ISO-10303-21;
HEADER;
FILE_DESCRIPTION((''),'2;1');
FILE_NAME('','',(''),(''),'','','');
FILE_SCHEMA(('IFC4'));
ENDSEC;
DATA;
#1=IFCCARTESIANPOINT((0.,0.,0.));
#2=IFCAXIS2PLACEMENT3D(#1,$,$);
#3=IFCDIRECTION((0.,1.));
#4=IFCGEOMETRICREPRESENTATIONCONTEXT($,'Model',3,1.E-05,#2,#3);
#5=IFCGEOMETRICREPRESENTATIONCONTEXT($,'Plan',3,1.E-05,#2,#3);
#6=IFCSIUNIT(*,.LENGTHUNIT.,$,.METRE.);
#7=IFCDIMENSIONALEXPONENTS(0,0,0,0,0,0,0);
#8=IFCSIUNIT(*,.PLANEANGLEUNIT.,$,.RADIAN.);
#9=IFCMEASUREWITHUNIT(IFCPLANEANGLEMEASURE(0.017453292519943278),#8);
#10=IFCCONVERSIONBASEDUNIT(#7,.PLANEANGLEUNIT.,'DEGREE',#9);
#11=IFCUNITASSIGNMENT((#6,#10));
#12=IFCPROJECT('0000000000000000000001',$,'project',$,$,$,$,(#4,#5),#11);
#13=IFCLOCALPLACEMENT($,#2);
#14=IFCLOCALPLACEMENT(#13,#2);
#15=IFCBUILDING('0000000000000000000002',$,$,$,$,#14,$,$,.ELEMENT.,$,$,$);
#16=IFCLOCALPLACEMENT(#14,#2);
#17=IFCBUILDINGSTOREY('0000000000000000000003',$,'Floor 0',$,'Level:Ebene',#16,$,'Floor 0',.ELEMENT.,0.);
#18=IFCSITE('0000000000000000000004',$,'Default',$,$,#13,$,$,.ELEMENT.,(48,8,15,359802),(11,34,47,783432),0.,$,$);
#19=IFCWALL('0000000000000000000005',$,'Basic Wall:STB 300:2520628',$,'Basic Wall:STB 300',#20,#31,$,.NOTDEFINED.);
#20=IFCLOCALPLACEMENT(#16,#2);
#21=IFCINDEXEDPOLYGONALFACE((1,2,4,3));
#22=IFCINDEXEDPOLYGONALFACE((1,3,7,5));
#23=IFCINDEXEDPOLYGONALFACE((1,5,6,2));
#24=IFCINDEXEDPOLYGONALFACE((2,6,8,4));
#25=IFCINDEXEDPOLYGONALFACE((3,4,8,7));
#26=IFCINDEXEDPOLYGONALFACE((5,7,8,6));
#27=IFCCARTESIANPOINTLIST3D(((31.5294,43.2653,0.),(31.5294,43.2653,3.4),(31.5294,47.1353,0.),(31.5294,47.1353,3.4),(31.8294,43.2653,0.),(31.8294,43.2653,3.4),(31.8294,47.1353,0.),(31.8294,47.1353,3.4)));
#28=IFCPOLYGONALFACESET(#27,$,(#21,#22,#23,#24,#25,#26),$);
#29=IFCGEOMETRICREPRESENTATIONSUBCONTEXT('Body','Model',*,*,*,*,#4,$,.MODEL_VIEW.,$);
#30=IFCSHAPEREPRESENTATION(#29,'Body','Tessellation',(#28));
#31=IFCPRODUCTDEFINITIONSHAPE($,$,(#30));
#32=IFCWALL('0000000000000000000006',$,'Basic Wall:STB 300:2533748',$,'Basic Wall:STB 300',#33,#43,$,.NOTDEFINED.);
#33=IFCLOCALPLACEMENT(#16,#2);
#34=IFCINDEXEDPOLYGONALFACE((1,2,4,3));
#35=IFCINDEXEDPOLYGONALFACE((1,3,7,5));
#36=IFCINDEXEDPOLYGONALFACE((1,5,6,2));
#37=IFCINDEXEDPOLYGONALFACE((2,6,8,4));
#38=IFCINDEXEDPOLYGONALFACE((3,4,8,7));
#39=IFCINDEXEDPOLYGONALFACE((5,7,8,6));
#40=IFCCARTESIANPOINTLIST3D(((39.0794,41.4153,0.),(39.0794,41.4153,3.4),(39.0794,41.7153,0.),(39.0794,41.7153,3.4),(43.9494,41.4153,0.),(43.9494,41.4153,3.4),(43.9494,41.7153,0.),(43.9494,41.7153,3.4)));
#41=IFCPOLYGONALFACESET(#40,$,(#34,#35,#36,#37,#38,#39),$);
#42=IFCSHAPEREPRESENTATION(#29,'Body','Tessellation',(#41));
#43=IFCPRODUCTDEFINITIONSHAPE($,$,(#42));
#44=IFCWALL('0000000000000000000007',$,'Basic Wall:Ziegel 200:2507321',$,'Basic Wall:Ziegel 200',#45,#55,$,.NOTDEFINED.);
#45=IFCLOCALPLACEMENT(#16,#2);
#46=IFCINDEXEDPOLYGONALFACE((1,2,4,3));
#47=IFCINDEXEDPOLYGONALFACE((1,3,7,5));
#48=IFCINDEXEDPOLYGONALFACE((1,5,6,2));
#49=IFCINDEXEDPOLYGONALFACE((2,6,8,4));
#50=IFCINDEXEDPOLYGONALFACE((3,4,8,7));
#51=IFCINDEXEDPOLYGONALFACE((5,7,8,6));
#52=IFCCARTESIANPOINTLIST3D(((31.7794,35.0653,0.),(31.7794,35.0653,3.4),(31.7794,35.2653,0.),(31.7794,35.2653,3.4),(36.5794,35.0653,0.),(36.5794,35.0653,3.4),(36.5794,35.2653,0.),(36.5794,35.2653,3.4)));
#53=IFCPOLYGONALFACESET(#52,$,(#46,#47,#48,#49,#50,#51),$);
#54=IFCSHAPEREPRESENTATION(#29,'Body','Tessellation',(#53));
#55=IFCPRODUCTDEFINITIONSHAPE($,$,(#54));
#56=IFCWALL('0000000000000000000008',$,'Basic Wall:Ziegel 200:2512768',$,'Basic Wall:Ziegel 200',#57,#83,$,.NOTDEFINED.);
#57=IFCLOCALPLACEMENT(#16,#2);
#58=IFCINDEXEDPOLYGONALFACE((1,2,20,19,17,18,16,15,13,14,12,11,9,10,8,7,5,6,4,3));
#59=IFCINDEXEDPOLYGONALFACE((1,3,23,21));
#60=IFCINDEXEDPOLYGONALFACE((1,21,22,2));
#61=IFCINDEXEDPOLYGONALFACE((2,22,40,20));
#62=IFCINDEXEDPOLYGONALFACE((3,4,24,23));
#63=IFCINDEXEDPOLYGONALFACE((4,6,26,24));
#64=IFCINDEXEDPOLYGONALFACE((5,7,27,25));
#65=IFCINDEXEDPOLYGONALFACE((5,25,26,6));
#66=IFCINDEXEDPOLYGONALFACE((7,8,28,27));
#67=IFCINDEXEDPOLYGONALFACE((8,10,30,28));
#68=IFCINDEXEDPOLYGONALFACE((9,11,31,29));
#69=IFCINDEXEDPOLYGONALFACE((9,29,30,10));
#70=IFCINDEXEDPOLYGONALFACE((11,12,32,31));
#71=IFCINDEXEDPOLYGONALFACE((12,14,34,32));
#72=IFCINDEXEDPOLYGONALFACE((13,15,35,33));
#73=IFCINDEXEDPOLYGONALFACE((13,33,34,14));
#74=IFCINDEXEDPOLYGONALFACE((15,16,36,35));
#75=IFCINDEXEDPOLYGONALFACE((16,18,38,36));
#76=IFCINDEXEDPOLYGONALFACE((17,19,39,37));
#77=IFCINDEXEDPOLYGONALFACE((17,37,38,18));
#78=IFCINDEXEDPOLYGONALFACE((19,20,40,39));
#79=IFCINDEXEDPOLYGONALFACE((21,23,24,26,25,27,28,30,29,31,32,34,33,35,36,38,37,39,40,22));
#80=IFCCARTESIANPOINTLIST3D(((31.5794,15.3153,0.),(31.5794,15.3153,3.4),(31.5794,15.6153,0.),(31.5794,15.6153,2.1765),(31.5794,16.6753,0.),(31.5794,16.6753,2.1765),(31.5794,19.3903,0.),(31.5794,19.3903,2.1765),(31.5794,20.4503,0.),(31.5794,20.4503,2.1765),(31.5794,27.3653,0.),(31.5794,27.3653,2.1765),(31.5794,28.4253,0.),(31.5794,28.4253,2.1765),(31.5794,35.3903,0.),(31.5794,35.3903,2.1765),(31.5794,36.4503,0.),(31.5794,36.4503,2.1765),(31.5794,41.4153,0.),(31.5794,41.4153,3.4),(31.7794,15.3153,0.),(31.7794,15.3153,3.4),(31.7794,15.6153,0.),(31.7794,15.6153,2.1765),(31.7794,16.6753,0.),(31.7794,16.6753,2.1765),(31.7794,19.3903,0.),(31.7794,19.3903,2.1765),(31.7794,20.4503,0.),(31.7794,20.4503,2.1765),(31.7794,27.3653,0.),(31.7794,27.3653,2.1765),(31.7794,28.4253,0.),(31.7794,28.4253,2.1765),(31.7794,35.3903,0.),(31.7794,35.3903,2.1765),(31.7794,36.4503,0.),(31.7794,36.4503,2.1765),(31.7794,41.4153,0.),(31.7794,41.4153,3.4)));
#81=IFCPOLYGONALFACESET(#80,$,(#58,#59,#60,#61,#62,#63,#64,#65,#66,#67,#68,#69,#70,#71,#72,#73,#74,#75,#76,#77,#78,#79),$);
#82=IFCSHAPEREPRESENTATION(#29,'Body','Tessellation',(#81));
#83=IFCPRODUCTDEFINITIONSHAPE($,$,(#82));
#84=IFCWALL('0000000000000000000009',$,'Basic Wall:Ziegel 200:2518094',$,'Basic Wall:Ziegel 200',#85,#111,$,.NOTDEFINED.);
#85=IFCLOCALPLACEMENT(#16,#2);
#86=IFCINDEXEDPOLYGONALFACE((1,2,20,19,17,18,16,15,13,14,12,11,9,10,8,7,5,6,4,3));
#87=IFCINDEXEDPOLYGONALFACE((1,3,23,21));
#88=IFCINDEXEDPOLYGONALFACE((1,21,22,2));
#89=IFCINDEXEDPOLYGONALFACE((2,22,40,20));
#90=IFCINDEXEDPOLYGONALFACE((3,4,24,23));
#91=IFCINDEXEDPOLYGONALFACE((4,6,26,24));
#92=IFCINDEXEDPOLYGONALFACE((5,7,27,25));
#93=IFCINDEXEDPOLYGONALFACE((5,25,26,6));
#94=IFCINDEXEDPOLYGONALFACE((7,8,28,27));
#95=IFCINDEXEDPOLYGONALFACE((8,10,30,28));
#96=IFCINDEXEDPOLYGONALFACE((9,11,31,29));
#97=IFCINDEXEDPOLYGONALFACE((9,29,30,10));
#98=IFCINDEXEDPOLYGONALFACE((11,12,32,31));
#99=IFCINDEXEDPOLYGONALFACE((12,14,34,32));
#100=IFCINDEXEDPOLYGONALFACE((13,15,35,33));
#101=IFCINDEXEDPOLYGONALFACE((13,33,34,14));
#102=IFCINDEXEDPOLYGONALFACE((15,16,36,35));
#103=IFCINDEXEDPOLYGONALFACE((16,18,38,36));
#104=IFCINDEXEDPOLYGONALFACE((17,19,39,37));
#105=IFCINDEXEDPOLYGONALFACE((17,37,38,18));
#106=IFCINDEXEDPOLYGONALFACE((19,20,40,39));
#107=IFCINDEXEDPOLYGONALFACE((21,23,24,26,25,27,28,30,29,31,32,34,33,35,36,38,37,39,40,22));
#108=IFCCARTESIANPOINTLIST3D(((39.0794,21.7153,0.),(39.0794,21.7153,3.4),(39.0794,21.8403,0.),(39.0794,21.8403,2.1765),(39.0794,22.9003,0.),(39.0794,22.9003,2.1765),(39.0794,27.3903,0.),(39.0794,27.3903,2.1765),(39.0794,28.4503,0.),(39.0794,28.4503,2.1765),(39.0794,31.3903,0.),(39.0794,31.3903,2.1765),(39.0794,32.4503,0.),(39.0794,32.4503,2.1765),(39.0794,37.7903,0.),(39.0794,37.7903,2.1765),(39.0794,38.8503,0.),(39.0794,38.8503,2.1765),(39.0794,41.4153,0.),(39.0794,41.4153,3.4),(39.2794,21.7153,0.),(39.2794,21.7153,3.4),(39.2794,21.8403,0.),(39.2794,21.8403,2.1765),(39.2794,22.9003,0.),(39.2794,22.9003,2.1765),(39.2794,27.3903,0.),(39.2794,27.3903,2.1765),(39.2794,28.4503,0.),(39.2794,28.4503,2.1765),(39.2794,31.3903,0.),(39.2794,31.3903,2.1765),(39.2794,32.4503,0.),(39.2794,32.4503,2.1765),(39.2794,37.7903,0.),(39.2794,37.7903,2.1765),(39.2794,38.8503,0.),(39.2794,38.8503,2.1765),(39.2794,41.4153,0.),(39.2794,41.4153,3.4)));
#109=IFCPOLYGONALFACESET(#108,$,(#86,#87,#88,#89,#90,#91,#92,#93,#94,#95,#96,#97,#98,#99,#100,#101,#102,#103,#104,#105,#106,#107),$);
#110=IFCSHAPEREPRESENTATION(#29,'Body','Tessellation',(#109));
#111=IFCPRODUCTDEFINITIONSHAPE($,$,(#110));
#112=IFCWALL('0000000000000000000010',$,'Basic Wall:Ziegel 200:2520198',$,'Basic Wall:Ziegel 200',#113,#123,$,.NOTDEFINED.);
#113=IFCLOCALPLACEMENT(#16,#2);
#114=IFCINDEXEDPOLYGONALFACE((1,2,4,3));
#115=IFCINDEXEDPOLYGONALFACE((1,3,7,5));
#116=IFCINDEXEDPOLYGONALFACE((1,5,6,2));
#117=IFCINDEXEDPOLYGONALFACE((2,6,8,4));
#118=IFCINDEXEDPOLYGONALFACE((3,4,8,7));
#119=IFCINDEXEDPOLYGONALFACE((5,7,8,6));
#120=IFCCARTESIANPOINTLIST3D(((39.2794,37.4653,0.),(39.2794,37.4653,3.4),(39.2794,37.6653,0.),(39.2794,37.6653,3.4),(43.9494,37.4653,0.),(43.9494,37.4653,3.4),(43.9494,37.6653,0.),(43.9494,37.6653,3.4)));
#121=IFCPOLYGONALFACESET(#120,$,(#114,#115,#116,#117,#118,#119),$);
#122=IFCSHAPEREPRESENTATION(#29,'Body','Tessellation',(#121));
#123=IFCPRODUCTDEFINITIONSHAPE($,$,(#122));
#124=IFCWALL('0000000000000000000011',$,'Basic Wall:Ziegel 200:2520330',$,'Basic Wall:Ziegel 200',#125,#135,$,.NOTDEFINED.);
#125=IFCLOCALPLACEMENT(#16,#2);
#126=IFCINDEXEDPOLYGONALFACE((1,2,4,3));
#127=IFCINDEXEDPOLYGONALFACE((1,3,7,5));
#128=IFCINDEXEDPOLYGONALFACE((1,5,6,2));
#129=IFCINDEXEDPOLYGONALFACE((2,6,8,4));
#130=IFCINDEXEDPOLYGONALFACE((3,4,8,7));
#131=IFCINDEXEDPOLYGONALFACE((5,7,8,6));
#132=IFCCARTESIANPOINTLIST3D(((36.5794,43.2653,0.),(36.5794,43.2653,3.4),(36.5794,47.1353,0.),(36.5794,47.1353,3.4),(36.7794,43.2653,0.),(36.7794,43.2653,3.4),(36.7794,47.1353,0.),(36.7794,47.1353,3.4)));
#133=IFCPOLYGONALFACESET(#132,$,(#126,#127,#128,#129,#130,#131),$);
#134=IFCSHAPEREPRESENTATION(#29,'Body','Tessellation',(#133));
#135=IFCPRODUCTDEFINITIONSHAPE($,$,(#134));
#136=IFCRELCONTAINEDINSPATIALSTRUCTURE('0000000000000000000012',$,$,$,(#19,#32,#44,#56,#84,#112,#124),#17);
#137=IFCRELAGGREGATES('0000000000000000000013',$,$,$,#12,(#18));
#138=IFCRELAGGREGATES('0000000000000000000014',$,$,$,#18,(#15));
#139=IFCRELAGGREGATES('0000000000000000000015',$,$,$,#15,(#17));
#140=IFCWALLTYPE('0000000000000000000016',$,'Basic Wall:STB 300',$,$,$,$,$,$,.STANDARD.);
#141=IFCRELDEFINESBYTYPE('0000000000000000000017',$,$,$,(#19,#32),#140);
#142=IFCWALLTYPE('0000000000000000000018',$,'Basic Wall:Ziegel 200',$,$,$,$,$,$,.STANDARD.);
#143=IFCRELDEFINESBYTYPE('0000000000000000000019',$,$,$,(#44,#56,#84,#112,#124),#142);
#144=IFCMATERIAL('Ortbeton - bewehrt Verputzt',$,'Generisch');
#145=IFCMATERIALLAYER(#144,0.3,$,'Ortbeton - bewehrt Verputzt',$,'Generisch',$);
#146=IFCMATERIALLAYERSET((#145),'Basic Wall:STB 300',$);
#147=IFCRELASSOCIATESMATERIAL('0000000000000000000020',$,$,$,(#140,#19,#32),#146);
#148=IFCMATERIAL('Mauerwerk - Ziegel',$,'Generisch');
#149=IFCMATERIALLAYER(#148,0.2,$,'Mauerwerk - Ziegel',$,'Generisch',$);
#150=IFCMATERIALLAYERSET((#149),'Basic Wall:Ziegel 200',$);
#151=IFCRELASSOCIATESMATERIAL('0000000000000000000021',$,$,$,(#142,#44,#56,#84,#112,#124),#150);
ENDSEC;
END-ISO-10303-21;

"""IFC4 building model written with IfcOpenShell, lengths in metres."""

from ifc_helpers import new_model, entity, si_unit, converted_unit, direction, frame, frame_2d, origin, place, context, subcontext, project, spatial, polyline, rectangle, extrude, clip, bounded_halfspace, material, layer, layer_set, layer_usage, type_object, element, save


model = new_model("IFC4")

# Units and contexts
model_context = context("Model", 3, precision=1e-05, world=origin(), true_north=direction((0.0, 1.0)))
plan_context = context("Plan", 3, precision=1e-05, world=origin(), true_north=direction((0.0, 1.0)))
body_context = subcontext(model_context, "Body", "Model", "MODEL_VIEW")
ifc_project = project(units=[si_unit("LENGTHUNIT", "METRE"), converted_unit("PLANEANGLEUNIT", "DEGREE", entity("IfcPlaneAngleMeasure", 0.017453292519943278), si_unit("PLANEANGLEUNIT", "RADIAN"), dimensions=[0, 0, 0, 0, 0, 0, 0])], contexts=[model_context, plan_context])

# Site, building, storey
site_placement = place(None, origin())
site = spatial("IfcSite", under=ifc_project, at=site_placement, Name="Default", CompositionType="ELEMENT", RefLatitude=(48, 8, 15, 359802), RefLongitude=(11, 34, 47, 783432), RefElevation=0.0)
building_placement = place(site_placement, origin())
building = spatial("IfcBuilding", under=site, at=building_placement, CompositionType="ELEMENT")
storey_placement = place(building_placement, origin())
storey = spatial("IfcBuildingStorey", under=building, at=storey_placement, Name="Floor 0", ObjectType="Level:Ebene", LongName="Floor 0", CompositionType="ELEMENT", Elevation=0.0)

# Walls
ifc_material_1 = material(Name="Ortbeton - bewehrt Verputzt", Category="Generisch")
ifc_layer_1 = layer(ifc_material_1, 0.3, Name="Ortbeton - bewehrt Verputzt", Category="Generisch")
ifc_layer_set_1 = layer_set([ifc_layer_1], Name="Basic Wall:STB 300")
ifc_layer_usage_1 = layer_usage(ifc_layer_set_1, "AXIS2", "NEGATIVE", 0.15)
wall_type_1 = type_object("IfcWallType", Name="Basic Wall:STB 300", PredefinedType="STANDARD", material=ifc_layer_set_1)
wall_1_placement = place(storey_placement, frame((31.6794, 47.1353, 0.0), z_axis=(0.0, 0.0, 1.0), x_axis=(0.0, -1.0, 0.0)))
element("IfcWall", 1, at=wall_1_placement, inside=storey, type_object=wall_type_1, material=ifc_layer_usage_1, Name="Basic Wall:STB 300:2520628", ObjectType="Basic Wall:STB 300", PredefinedType="NOTDEFINED", context=body_context, shape_type="Clipping", body=[
    clip(extrude(rectangle(XDim=3.87, YDim=0.3, at=frame_2d((1.935, 0.0), x_axis=(-1.0, 0.0))), origin(), (0.0, 0.0, 1.0), 3.4), bounded_halfspace(frame((0.0, -0.15, 3.4), z_axis=(0.0, 0.0, -1.0), x_axis=(0.0, -1.0, 0.0)), True, frame((0.0, -0.15, 3.4)), polyline([(0.0, 0.0), (3.57, 0.0), (3.87, 0.0), (3.87, 0.3), (0.0, 0.3), (0.0, 0.0)]))),
])
wall_2_placement = place(storey_placement, frame((39.0794, 41.5653, 0.0)))
element("IfcWall", 2, at=wall_2_placement, inside=storey, type_object=wall_type_1, material=ifc_layer_usage_1, Name="Basic Wall:STB 300:2533748", ObjectType="Basic Wall:STB 300", PredefinedType="NOTDEFINED", context=body_context, shape_type="Clipping", body=[
    clip(extrude(rectangle(XDim=4.87, YDim=0.3, at=frame_2d((2.435, 0.0), x_axis=(-1.0, 0.0))), origin(), (0.0, 0.0, 1.0), 3.4), bounded_halfspace(frame((0.0, -0.15, 3.4), z_axis=(0.0, 0.0, -1.0), x_axis=(-1.0, 0.0, 0.0)), True, frame((0.0, -0.15, 3.4)), polyline([(0.0, 0.0), (0.2, 0.0), (4.87, 0.0), (4.87, 0.3), (0.0, 0.3), (0.0, 0.0)]))),
])
ifc_material_2 = material(Name="Mauerwerk - Ziegel", Category="Generisch")
ifc_layer_2 = layer(ifc_material_2, 0.2, Name="Mauerwerk - Ziegel", Category="Generisch")
ifc_layer_set_2 = layer_set([ifc_layer_2], Name="Basic Wall:Ziegel 200")
ifc_layer_usage_2 = layer_usage(ifc_layer_set_2, "AXIS2", "NEGATIVE", 0.1)
wall_type_2 = type_object("IfcWallType", Name="Basic Wall:Ziegel 200", PredefinedType="STANDARD", material=ifc_layer_set_2)
wall_3_placement = place(storey_placement, frame((36.5794, 35.1653, 0.0), z_axis=(0.0, 0.0, 1.0), x_axis=(-1.0, 0.0, 0.0)))
element("IfcWall", 3, at=wall_3_placement, inside=storey, type_object=wall_type_2, material=ifc_layer_usage_2, Name="Basic Wall:Ziegel 200:2507321", ObjectType="Basic Wall:Ziegel 200", PredefinedType="NOTDEFINED", context=body_context, shape_type="Clipping", body=[
    clip(extrude(rectangle(XDim=4.8, YDim=0.2, at=frame_2d((2.4, 0.0), x_axis=(-1.0, 0.0))), origin(), (0.0, 0.0, 1.0), 3.4), bounded_halfspace(frame((0.0, -0.1, 3.4), z_axis=(0.0, 0.0, -1.0), x_axis=(1.0, 0.0, 0.0)), True, frame((0.0, -0.1, 3.4)), polyline([(0.0, 0.0), (4.8, 0.0), (4.8, 0.2), (0.0, 0.2), (0.0, 0.0)]))),
])

# Walls, openings
wall_4_placement = place(storey_placement, frame((31.6794, 41.4153, 0.0), z_axis=(0.0, 0.0, 1.0), x_axis=(0.0, -1.0, 0.0)))
wall_4 = element("IfcWall", 4, at=wall_4_placement, inside=storey, type_object=wall_type_2, material=ifc_layer_usage_2, Name="Basic Wall:Ziegel 200:2512768", ObjectType="Basic Wall:Ziegel 200", PredefinedType="NOTDEFINED", context=body_context, shape_type="Clipping", body=[
    clip(extrude(rectangle(XDim=26.1, YDim=0.2, at=frame_2d((13.05, 0.0), x_axis=(-1.0, 0.0))), origin(), (0.0, 0.0, 1.0), 3.4), bounded_halfspace(frame((0.0, -0.1, 3.4), z_axis=(0.0, 0.0, -1.0), x_axis=(0.0, -1.0, 0.0)), True, frame((0.0, -0.1, 3.4)), polyline([(0.0, 0.0), (26.1, 0.0), (26.1, 0.2), (22.35, 0.2), (22.15, 0.2), (14.35, 0.2), (14.15, 0.2), (6.35, 0.2), (6.15, 0.2), (0.0, 0.2), (0.0, 0.0)]))),
])
opening_1_placement = place(wall_4_placement, frame((6.025, 0.1, 0.0)))
element("IfcOpeningElement", 5, at=opening_1_placement, cuts=wall_4, PredefinedType="OPENING", context=body_context, shape_type="SweptSolid", body=[
    extrude(rectangle(XDim=2.1765, YDim=1.06, at=frame_2d((1.0882, 0.53), x_axis=(1.0, 0.0))), frame((0.0, 0.0, 0.0), z_axis=(0.0, -1.0, 0.0), x_axis=(0.0, 0.0, 1.0)), (0.0, 0.0, 1.0), 0.2),
])
opening_2_placement = place(wall_4_placement, frame((14.05, 0.1, 0.0)))
element("IfcOpeningElement", 6, at=opening_2_placement, cuts=wall_4, PredefinedType="OPENING", context=body_context, shape_type="SweptSolid", body=[
    extrude(rectangle(XDim=2.1765, YDim=1.06, at=frame_2d((1.0882, 0.53), x_axis=(1.0, 0.0))), frame((0.0, 0.0, 0.0), z_axis=(0.0, -1.0, 0.0), x_axis=(0.0, 0.0, 1.0)), (0.0, 0.0, 1.0), 0.2),
])
opening_3_placement = place(wall_4_placement, frame((22.025, 0.1, 0.0)))
element("IfcOpeningElement", 7, at=opening_3_placement, cuts=wall_4, PredefinedType="OPENING", context=body_context, shape_type="SweptSolid", body=[
    extrude(rectangle(XDim=2.1765, YDim=1.06, at=frame_2d((1.0882, 0.53), x_axis=(1.0, 0.0))), frame((0.0, 0.0, 0.0), z_axis=(0.0, -1.0, 0.0), x_axis=(0.0, 0.0, 1.0)), (0.0, 0.0, 1.0), 0.2),
])
opening_4_placement = place(wall_4_placement, frame((24.74, -0.1, 0.0)))
element("IfcOpeningElement", 8, at=opening_4_placement, cuts=wall_4, PredefinedType="OPENING", context=body_context, shape_type="SweptSolid", body=[
    extrude(rectangle(XDim=2.1765, YDim=1.06, at=frame_2d((1.0882, 0.53), x_axis=(1.0, 0.0))), frame((0.0, 0.0, 0.0), z_axis=(0.0, 1.0, 0.0), x_axis=(0.0, 0.0, 1.0)), (0.0, 0.0, 1.0), 0.2),
])
wall_5_placement = place(storey_placement, frame((39.1794, 41.4153, 0.0), z_axis=(0.0, 0.0, 1.0), x_axis=(0.0, -1.0, 0.0)))
wall_5 = element("IfcWall", 9, at=wall_5_placement, inside=storey, type_object=wall_type_2, material=ifc_layer_usage_2, Name="Basic Wall:Ziegel 200:2518094", ObjectType="Basic Wall:Ziegel 200", PredefinedType="NOTDEFINED", context=body_context, shape_type="Clipping", body=[
    clip(extrude(rectangle(XDim=19.7, YDim=0.2, at=frame_2d((9.85, 0.0), x_axis=(-1.0, 0.0))), origin(), (0.0, 0.0, 1.0), 3.4), bounded_halfspace(frame((0.0, -0.1, 3.4), z_axis=(0.0, 0.0, -1.0), x_axis=(0.0, -1.0, 0.0)), True, frame((0.0, -0.1, 3.4)), polyline([(0.0, 0.0), (19.7, 0.0), (19.7, 0.2), (14.35, 0.2), (14.15, 0.2), (10.35, 0.2), (10.15, 0.2), (3.95, 0.2), (3.75, 0.2), (0.0, 0.2), (0.0, 0.0)]))),
])
opening_5_placement = place(wall_5_placement, frame((14.025, 0.1, 0.0)))
element("IfcOpeningElement", 10, at=opening_5_placement, cuts=wall_5, PredefinedType="OPENING", context=body_context, shape_type="SweptSolid", body=[
    extrude(rectangle(XDim=2.1765, YDim=1.06, at=frame_2d((1.0882, 0.53), x_axis=(1.0, 0.0))), frame((0.0, 0.0, 0.0), z_axis=(0.0, -1.0, 0.0), x_axis=(0.0, 0.0, 1.0)), (0.0, 0.0, 1.0), 0.2),
])
opening_6_placement = place(wall_5_placement, frame((10.025, 0.1, 0.0)))
element("IfcOpeningElement", 11, at=opening_6_placement, cuts=wall_5, PredefinedType="OPENING", context=body_context, shape_type="SweptSolid", body=[
    extrude(rectangle(XDim=2.1765, YDim=1.06, at=frame_2d((1.0882, 0.53), x_axis=(1.0, 0.0))), frame((0.0, 0.0, 0.0), z_axis=(0.0, -1.0, 0.0), x_axis=(0.0, 0.0, 1.0)), (0.0, 0.0, 1.0), 0.2),
])
opening_7_placement = place(wall_5_placement, frame((3.625, 0.1, 0.0)))
element("IfcOpeningElement", 12, at=opening_7_placement, cuts=wall_5, PredefinedType="OPENING", context=body_context, shape_type="SweptSolid", body=[
    extrude(rectangle(XDim=2.1765, YDim=1.06, at=frame_2d((1.0882, 0.53), x_axis=(1.0, 0.0))), frame((0.0, 0.0, 0.0), z_axis=(0.0, -1.0, 0.0), x_axis=(0.0, 0.0, 1.0)), (0.0, 0.0, 1.0), 0.2),
])
opening_8_placement = place(wall_5_placement, frame((19.575, 0.1, 0.0)))
element("IfcOpeningElement", 13, at=opening_8_placement, cuts=wall_5, PredefinedType="OPENING", context=body_context, shape_type="SweptSolid", body=[
    extrude(rectangle(XDim=2.1765, YDim=1.06, at=frame_2d((1.0882, 0.53), x_axis=(1.0, 0.0))), frame((0.0, 0.0, 0.0), z_axis=(0.0, -1.0, 0.0), x_axis=(0.0, 0.0, 1.0)), (0.0, 0.0, 1.0), 0.2),
])

# Walls
wall_6_placement = place(storey_placement, frame((43.9494, 37.5653, 0.0), z_axis=(0.0, 0.0, 1.0), x_axis=(-1.0, 0.0, 0.0)))
element("IfcWall", 14, at=wall_6_placement, inside=storey, type_object=wall_type_2, material=ifc_layer_usage_2, Name="Basic Wall:Ziegel 200:2520198", ObjectType="Basic Wall:Ziegel 200", PredefinedType="NOTDEFINED", context=body_context, shape_type="Clipping", body=[
    clip(extrude(rectangle(XDim=4.67, YDim=0.2, at=frame_2d((2.335, 0.0), x_axis=(-1.0, 0.0))), origin(), (0.0, 0.0, 1.0), 3.4), bounded_halfspace(frame((0.0, -0.1, 3.4), z_axis=(0.0, 0.0, -1.0), x_axis=(1.0, 0.0, 0.0)), True, frame((0.0, -0.1, 3.4)), polyline([(0.0, 0.0), (4.67, 0.0), (4.67, 0.2), (0.0, 0.2), (0.0, 0.0)]))),
])
wall_7_placement = place(storey_placement, frame((36.6794, 47.1353, 0.0), z_axis=(0.0, 0.0, 1.0), x_axis=(0.0, -1.0, 0.0)))
element("IfcWall", 15, at=wall_7_placement, inside=storey, type_object=wall_type_2, material=ifc_layer_usage_2, Name="Basic Wall:Ziegel 200:2520330", ObjectType="Basic Wall:Ziegel 200", PredefinedType="NOTDEFINED", context=body_context, shape_type="Clipping", body=[
    clip(extrude(rectangle(XDim=3.87, YDim=0.2, at=frame_2d((1.935, 0.0), x_axis=(-1.0, 0.0))), origin(), (0.0, 0.0, 1.0), 3.4), bounded_halfspace(frame((0.0, -0.1, 3.4), z_axis=(0.0, 0.0, -1.0), x_axis=(0.0, -1.0, 0.0)), True, frame((0.0, -0.1, 3.4)), polyline([(0.0, 0.0), (2.12, 0.0), (2.22, 0.0), (3.67, 0.0), (3.87, 0.0), (3.87, 0.2), (0.0, 0.2), (0.0, 0.0)]))),
])

save(model, "model.ifc")
